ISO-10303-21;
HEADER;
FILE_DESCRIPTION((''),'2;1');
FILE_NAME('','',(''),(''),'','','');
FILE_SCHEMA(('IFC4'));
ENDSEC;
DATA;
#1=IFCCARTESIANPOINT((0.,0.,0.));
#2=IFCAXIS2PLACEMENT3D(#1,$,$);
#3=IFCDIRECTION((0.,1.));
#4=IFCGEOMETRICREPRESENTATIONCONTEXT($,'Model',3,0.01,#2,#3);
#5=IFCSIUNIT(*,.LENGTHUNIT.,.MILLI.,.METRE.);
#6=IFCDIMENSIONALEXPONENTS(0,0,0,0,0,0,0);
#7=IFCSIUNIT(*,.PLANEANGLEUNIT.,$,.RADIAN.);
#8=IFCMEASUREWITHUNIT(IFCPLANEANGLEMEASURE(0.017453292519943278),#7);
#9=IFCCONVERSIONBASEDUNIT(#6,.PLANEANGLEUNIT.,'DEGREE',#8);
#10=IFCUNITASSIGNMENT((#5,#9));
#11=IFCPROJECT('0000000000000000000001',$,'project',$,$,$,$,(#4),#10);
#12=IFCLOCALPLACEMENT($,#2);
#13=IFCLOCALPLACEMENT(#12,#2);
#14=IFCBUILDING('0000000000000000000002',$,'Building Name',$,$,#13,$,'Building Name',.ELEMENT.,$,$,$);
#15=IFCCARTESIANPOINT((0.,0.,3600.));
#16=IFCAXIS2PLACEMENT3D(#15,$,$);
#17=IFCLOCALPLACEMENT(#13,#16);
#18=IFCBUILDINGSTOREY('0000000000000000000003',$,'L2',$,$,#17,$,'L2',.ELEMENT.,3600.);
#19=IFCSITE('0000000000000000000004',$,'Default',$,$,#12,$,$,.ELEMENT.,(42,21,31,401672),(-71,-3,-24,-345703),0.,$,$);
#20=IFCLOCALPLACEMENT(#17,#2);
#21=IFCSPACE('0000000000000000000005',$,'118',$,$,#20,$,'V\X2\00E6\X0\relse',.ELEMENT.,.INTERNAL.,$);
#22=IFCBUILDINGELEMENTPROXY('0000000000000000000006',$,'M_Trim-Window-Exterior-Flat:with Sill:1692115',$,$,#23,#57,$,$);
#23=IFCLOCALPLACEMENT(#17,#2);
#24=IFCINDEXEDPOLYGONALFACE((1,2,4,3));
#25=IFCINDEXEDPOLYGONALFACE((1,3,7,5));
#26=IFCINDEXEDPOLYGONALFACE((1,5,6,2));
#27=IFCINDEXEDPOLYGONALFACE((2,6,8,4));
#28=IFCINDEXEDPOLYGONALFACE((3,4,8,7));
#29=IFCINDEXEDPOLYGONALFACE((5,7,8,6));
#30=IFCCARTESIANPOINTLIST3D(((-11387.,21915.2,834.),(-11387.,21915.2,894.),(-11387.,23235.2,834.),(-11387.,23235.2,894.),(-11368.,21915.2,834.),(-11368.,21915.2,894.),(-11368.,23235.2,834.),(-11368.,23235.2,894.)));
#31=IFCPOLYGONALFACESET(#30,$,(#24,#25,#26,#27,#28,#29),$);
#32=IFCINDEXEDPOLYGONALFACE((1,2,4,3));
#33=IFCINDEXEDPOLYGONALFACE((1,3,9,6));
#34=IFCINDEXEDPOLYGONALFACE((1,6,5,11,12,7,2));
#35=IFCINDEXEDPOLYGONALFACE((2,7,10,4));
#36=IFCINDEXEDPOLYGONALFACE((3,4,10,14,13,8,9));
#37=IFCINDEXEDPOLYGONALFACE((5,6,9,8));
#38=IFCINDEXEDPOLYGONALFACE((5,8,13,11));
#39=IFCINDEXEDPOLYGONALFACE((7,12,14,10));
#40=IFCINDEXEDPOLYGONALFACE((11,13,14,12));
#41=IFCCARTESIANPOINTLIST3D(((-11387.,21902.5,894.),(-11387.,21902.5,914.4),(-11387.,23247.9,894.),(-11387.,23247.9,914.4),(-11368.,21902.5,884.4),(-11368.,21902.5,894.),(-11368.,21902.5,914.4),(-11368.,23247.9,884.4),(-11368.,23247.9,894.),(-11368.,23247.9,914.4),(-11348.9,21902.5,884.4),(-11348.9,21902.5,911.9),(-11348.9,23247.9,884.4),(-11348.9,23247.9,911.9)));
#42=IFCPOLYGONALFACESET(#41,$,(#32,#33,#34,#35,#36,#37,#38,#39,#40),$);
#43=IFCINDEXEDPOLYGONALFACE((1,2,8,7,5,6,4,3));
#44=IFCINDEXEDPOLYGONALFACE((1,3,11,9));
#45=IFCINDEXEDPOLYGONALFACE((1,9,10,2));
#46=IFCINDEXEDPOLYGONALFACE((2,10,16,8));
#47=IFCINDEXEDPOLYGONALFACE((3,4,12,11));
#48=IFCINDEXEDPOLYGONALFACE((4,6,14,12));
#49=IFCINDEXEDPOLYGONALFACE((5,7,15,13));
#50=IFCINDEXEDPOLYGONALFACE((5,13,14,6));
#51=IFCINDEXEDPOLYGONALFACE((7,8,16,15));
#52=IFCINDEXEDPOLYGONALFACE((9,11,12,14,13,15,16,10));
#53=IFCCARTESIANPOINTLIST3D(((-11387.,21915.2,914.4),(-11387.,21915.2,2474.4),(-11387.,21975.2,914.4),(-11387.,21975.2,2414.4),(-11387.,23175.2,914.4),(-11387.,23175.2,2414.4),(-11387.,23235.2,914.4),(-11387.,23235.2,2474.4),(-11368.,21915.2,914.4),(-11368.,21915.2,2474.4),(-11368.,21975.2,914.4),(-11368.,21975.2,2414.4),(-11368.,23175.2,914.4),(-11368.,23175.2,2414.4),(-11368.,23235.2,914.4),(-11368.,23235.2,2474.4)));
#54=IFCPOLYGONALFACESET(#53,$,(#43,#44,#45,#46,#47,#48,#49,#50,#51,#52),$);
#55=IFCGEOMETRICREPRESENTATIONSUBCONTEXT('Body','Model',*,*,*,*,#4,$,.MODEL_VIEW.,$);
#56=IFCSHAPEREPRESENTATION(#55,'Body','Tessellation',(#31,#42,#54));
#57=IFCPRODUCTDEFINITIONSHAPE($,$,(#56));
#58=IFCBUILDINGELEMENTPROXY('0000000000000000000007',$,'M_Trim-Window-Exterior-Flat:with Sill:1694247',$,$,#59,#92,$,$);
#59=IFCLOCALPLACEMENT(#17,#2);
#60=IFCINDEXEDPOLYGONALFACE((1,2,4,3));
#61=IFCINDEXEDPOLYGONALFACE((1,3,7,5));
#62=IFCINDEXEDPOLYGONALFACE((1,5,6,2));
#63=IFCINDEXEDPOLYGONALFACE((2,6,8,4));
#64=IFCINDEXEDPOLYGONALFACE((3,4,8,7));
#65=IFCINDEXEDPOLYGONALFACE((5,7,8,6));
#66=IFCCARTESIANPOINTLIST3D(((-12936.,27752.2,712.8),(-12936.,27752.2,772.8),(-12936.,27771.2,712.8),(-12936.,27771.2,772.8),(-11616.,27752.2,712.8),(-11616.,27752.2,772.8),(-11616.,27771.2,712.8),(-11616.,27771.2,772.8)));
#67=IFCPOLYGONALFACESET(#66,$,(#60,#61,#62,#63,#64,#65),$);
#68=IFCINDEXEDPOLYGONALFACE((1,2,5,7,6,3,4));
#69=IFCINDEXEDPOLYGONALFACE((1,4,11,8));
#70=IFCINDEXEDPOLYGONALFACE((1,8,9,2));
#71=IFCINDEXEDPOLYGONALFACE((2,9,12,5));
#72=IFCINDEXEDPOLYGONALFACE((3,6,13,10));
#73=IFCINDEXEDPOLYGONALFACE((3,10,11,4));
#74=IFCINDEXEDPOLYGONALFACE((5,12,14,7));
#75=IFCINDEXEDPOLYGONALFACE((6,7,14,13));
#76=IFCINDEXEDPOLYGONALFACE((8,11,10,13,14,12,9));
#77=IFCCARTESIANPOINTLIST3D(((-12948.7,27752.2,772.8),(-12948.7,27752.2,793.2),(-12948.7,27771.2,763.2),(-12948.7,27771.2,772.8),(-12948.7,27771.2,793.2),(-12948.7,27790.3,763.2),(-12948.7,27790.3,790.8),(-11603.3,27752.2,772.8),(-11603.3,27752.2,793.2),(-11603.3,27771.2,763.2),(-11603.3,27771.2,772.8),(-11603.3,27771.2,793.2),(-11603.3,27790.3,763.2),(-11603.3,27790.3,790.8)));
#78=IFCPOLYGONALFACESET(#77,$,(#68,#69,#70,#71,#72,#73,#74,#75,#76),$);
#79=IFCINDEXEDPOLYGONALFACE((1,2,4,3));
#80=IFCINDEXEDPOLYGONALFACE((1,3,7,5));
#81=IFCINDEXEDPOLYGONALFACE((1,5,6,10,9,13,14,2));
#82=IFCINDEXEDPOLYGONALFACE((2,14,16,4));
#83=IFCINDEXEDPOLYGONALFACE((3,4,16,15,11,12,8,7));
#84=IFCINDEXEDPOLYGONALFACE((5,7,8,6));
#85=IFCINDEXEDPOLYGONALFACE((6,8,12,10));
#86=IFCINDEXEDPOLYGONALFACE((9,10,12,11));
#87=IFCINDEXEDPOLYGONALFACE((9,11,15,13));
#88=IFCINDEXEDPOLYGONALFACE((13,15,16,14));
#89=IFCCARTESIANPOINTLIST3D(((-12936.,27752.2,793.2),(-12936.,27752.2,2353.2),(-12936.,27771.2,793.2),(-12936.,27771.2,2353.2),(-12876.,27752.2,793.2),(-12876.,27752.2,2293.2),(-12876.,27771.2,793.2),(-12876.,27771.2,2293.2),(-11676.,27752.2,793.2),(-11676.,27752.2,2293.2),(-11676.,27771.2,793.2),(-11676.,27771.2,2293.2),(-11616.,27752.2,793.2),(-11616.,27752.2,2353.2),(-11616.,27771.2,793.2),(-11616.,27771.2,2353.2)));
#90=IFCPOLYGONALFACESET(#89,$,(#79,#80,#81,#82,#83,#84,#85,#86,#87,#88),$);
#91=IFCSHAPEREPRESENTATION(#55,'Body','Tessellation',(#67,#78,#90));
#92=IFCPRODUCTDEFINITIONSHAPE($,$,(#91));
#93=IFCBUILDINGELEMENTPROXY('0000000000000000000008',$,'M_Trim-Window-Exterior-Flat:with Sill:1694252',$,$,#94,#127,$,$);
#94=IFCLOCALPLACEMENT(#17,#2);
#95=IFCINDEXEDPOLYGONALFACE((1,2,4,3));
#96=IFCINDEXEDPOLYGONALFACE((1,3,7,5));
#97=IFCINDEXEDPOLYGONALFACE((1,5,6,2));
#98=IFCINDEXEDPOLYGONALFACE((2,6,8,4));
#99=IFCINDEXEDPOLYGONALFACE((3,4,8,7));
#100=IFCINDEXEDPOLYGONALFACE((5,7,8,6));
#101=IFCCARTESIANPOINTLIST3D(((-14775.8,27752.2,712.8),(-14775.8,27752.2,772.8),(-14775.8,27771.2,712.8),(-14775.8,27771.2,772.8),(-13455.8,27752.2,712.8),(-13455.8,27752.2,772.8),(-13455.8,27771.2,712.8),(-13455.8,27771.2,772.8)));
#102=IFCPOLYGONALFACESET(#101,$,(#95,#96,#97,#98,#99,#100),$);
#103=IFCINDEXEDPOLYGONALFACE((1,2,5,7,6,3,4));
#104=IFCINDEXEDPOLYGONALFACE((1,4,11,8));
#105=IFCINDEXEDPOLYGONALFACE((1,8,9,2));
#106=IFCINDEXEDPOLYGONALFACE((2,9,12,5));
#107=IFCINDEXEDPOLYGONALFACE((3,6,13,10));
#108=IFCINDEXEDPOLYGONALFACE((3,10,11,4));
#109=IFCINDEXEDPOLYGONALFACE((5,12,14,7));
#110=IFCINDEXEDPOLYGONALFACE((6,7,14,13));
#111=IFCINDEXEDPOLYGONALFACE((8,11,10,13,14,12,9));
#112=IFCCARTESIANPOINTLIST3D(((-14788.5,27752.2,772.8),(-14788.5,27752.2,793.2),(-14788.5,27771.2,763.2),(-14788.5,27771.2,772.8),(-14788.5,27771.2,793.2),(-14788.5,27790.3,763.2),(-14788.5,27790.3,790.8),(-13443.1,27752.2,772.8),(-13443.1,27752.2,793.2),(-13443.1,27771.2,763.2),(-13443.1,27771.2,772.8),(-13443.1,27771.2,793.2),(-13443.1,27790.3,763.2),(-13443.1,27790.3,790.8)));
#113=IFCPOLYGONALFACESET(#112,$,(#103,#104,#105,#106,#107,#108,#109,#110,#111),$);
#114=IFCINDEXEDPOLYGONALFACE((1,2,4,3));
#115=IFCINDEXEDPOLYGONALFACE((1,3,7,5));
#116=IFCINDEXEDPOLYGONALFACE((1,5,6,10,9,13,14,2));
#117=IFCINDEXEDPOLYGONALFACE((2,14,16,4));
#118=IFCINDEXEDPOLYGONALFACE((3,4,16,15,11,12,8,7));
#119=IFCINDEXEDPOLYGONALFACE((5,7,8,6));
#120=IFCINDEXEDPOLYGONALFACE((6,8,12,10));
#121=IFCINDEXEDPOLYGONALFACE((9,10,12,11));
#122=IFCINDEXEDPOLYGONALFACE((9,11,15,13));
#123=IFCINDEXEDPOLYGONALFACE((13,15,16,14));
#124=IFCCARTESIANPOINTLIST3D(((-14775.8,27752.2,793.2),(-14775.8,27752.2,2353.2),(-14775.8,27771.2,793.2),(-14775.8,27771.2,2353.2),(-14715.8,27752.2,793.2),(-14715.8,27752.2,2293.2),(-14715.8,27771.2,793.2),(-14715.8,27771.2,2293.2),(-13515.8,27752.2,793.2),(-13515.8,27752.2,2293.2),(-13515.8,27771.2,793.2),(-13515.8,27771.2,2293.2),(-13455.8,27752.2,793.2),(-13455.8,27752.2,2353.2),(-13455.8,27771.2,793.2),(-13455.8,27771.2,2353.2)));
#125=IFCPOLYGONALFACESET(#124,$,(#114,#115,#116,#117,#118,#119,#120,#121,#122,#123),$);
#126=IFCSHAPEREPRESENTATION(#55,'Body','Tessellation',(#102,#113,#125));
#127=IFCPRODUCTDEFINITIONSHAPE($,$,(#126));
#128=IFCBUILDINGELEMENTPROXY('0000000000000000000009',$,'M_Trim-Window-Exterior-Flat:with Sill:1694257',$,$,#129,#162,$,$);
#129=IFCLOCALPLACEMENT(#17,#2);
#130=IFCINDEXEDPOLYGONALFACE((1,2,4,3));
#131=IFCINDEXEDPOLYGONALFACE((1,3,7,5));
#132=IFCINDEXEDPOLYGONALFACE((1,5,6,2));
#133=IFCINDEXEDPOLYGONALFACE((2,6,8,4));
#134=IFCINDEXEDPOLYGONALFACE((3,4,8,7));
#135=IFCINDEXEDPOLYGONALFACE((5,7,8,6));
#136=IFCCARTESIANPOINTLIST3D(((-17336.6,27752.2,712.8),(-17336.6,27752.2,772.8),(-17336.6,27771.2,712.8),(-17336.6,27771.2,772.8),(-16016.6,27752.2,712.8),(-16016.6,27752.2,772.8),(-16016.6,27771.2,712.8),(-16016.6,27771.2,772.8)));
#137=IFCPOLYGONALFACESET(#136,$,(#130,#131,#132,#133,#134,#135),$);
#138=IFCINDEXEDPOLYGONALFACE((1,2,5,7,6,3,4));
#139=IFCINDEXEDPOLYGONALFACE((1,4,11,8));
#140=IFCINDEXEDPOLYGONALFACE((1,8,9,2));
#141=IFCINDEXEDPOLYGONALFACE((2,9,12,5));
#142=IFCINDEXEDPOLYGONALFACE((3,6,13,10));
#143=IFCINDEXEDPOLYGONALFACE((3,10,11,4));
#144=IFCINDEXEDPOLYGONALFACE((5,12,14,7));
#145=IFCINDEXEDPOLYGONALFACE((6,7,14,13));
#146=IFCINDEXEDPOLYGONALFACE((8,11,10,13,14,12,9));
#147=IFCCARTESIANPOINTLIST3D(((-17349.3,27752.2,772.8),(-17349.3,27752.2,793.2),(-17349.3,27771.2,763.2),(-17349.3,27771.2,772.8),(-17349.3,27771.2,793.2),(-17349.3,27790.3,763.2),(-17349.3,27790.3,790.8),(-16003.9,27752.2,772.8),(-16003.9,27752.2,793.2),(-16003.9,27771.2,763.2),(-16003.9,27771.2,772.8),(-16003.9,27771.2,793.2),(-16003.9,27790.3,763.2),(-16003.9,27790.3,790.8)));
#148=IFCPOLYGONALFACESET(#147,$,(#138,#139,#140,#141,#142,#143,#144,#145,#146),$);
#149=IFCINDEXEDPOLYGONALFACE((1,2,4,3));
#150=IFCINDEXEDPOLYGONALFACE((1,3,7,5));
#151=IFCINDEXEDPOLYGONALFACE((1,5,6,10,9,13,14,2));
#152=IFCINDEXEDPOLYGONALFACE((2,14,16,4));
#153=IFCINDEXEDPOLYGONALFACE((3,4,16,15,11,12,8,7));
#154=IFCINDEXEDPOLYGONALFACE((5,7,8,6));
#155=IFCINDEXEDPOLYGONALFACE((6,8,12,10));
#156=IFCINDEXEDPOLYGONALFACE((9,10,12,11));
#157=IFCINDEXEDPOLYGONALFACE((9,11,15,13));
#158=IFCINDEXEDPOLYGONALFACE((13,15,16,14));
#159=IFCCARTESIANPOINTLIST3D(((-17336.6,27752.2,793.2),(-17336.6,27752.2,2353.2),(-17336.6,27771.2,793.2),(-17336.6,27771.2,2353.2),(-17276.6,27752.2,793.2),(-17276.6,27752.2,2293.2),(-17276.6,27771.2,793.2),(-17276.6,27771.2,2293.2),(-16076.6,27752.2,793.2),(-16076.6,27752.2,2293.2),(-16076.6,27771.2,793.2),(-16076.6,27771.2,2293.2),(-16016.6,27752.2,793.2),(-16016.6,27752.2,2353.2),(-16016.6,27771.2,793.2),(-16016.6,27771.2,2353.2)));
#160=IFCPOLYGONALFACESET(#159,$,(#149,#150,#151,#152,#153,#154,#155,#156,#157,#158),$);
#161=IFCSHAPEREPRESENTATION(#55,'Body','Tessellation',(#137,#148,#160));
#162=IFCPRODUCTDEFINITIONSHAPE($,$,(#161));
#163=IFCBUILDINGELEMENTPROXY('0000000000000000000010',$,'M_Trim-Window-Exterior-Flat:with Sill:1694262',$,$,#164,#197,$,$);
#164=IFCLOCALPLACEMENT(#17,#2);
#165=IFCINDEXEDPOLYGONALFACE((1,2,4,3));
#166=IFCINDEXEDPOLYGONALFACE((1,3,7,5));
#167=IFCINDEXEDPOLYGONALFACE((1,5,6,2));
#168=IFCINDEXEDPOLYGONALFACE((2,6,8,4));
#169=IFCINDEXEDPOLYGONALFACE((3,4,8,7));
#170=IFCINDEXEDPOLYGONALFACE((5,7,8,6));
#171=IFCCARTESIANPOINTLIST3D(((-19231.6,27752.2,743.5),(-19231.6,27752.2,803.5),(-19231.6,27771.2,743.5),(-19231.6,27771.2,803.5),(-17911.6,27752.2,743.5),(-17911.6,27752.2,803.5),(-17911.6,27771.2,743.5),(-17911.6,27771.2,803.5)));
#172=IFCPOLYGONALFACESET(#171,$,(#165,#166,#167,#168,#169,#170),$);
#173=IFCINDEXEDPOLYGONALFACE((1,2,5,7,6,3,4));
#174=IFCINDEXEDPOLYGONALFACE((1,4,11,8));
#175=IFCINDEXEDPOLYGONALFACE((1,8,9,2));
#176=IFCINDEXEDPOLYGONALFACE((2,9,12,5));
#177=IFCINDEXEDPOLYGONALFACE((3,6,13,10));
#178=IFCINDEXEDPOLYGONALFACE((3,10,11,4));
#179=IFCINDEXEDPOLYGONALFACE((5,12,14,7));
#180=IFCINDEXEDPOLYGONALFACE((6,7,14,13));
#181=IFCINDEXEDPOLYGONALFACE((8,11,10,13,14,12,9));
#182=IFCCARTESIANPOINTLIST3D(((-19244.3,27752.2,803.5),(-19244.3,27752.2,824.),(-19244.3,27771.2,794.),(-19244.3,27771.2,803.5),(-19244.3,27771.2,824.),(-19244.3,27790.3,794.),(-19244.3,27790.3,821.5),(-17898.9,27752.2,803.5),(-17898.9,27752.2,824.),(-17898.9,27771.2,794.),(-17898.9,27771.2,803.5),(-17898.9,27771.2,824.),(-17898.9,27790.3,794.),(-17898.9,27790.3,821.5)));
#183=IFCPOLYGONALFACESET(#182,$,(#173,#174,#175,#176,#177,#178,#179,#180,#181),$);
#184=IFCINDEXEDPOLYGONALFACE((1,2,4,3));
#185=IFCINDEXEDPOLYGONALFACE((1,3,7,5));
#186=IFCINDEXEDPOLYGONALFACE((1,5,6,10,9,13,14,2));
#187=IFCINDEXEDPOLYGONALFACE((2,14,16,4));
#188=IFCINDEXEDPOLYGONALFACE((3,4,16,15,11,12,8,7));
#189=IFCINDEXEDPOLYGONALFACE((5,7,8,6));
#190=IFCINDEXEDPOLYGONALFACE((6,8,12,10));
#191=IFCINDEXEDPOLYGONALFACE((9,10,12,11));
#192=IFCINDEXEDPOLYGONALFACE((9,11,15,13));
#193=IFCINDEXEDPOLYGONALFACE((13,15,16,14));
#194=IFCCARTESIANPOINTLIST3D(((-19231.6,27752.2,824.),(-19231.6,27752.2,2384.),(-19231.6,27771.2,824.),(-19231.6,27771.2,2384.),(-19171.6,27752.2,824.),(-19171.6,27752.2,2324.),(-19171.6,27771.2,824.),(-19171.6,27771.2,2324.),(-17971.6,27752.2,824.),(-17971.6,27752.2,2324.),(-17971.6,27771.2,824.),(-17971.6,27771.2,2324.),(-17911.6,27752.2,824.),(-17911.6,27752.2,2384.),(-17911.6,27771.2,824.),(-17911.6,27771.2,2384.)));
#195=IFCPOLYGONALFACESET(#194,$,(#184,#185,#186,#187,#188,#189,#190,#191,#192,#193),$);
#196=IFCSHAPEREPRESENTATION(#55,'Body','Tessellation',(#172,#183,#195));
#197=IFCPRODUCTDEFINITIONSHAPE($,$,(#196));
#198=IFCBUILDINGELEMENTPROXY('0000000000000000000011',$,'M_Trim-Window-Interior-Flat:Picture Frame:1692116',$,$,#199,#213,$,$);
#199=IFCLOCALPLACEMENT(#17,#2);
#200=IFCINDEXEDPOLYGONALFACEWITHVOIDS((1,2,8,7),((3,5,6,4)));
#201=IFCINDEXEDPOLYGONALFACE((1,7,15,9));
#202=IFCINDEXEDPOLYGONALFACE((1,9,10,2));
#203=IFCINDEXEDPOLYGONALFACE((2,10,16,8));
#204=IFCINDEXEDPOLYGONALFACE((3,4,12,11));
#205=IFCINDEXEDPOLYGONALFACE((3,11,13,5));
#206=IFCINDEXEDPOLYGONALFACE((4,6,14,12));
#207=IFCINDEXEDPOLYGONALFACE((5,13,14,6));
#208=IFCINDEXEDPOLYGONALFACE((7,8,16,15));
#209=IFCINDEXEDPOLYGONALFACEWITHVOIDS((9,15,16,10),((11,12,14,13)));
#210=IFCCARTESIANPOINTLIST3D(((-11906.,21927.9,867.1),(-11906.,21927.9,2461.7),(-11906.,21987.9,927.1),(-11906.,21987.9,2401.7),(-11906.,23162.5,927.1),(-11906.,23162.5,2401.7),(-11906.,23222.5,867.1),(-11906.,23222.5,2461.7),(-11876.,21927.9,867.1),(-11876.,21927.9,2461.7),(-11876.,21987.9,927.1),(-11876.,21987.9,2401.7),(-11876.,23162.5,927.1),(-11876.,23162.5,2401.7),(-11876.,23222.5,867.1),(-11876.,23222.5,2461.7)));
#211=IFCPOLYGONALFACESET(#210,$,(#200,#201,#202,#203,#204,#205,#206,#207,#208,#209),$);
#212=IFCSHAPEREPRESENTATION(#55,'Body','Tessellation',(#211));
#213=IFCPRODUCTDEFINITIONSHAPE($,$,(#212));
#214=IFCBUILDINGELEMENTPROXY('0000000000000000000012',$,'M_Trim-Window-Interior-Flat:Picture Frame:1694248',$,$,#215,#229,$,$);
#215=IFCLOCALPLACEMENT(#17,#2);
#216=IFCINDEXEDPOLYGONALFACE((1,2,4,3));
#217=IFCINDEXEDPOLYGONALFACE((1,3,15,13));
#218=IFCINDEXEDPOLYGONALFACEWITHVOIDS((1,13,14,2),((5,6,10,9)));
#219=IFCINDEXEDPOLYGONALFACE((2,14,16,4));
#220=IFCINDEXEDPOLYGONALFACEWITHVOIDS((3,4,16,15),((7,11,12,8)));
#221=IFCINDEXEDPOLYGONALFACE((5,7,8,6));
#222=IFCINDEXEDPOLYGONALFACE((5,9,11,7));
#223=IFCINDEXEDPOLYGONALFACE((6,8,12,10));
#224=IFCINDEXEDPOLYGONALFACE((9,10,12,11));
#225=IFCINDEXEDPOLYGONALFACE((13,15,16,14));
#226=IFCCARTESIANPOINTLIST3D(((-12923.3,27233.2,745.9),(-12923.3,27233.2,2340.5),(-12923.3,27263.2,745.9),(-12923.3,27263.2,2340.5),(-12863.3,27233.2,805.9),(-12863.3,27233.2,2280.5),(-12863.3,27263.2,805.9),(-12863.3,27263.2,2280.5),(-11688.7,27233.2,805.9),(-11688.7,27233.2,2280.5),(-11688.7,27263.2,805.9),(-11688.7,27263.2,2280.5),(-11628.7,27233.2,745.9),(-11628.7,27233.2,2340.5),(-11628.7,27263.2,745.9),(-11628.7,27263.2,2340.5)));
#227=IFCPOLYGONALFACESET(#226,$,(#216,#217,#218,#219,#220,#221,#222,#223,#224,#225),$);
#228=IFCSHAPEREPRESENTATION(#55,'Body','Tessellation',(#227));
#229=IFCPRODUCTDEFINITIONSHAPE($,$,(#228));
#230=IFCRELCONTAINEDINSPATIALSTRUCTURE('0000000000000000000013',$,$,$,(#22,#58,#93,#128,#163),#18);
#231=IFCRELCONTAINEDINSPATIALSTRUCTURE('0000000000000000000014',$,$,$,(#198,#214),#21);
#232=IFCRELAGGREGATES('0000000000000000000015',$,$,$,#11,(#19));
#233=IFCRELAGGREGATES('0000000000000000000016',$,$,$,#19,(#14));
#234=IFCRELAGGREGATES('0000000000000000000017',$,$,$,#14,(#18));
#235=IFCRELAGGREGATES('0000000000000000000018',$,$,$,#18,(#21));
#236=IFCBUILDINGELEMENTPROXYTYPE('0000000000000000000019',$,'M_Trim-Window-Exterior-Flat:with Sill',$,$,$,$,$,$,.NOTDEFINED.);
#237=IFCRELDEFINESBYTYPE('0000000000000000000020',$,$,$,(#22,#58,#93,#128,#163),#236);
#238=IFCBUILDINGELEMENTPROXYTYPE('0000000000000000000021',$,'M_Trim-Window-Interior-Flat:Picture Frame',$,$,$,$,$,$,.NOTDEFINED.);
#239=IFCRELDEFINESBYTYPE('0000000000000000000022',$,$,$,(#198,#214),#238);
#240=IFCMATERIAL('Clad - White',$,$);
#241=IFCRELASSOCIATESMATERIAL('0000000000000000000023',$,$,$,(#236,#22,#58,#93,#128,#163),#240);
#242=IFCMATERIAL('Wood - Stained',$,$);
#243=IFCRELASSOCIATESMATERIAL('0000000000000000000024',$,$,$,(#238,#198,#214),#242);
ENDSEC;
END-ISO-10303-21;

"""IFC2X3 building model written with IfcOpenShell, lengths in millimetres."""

from ifc_helpers import new_model, entity, si_unit, converted_unit, direction, frame, frame_2d, origin, place, context, subcontext, project, spatial, polyline, rectangle, outline, extrude, source, transform, mapped, material, type_object, type_shapes, element, save


model = new_model("IFC2X3")

# Units and contexts
model_context = context("Model", 3, precision=0.01, world=origin(), true_north=direction((0.0, 1.0)))
body_context = subcontext(model_context, "Body", "Model", "MODEL_VIEW")
ifc_project = project(units=[si_unit("LENGTHUNIT", "METRE", prefix="MILLI"), converted_unit("PLANEANGLEUNIT", "DEGREE", entity("IfcPlaneAngleMeasure", 0.017453292519943278), si_unit("PLANEANGLEUNIT", "RADIAN"), dimensions=[0, 0, 0, 0, 0, 0, 0])], contexts=[model_context])

# Site, building, storey
site_placement = place(None, origin())
site = spatial("IfcSite", under=ifc_project, at=site_placement, Name="Default", CompositionType="ELEMENT", RefLatitude=(42, 21, 31, 401672), RefLongitude=(-71, -3, -24, -345703), RefElevation=0.0)
building_placement = place(site_placement, origin())
building = spatial("IfcBuilding", under=site, at=building_placement, Name="Building Name", LongName="Building Name", CompositionType="ELEMENT")
storey_placement = place(building_placement, frame((0.0, 0.0, 3600.0)))
storey = spatial("IfcBuildingStorey", under=building, at=storey_placement, Name="L2", LongName="L2", CompositionType="ELEMENT", Elevation=3600.0)

# Shared definitions
ifc_material_1 = material(Name="Wood - Stained")

# Building element proxies
ifc_material_2 = material(Name="Clad - White")
building_element_proxy_type_1 = type_object("IfcBuildingElementProxyType", Name="M_Trim-Window-Exterior-Flat:with Sill", PredefinedType="NOTDEFINED", material=ifc_material_2)
shared_shape_1 = source(origin(), body_context, "Body", "SweptSolid", [
    extrude(rectangle(XDim=1320.0, YDim=60.0, at=frame_2d((0.0, 0.0), x_axis=(1.0, 0.0))), frame((0.0, -1550.4, 0.0), z_axis=(0.0, 0.0, 1.0), x_axis=(-1.0, 0.0, 0.0)), (0.0, 0.0, 1.0), 19.0),
    extrude(outline(polyline([(-19.0, -15.2), (0.0, -15.2), (0.0, -5.7), (19.0, -5.7), (19.0, 14.8), (0.0, 14.8), (-19.0, 12.3), (-19.0, -15.2)])), frame((-672.7, -1514.8, 19.0), z_axis=(1.0, 0.0, 0.0), x_axis=(0.0, 0.0, -1.0)), (0.0, 0.0, 1.0), 1345.4),
    extrude(outline(polyline([(-795.0, -660.0), (765.0, -660.0), (765.0, -600.0), (-735.0, -600.0), (-735.0, 600.0), (765.0, 600.0), (765.0, 660.0), (-795.0, 660.0), (-795.0, -660.0)])), frame((0.0, -735.0, 0.0), z_axis=(0.0, 0.0, 1.0), x_axis=(0.0, -1.0, 0.0)), (0.0, 0.0, 1.0), 19.0),
])
type_shapes(building_element_proxy_type_1, [shared_shape_1])
for number, where, z_axis, x_axis, name in (
    (1, (-11387.0, 22575.2, 2414.4), (1.0, 0.0, 0.0), (0.0, 1.0, 0.0), "M_Trim-Window-Exterior-Flat:with Sill:1692115"),
    (2, (-12276.0, 27752.2, 2293.2), (0.0, 1.0, 0.0), (-1.0, 0.0, 0.0), "M_Trim-Window-Exterior-Flat:with Sill:1694247"),
    (3, (-14115.8, 27752.2, 2293.2), (0.0, 1.0, 0.0), (-1.0, 0.0, 0.0), "M_Trim-Window-Exterior-Flat:with Sill:1694252"),
    (4, (-16676.6, 27752.2, 2293.2), (0.0, 1.0, 0.0), (-1.0, 0.0, 0.0), "M_Trim-Window-Exterior-Flat:with Sill:1694257"),
    (5, (-18571.6, 27752.2, 2324.0), (0.0, 1.0, 0.0), (-1.0, 0.0, 0.0), "M_Trim-Window-Exterior-Flat:with Sill:1694262"),
):
    element("IfcBuildingElementProxy", number, at=place(storey_placement, frame(where, z_axis=z_axis, x_axis=x_axis)), inside=storey, type_object=building_element_proxy_type_1, material=ifc_material_2, Name=name, context=body_context, shape_type="MappedRepresentation", body=[
        mapped(shared_shape_1, transform((0.0, 0.0, 0.0), scale=1.0)),
    ])

# Shared definitions
space_1_placement = place(storey_placement, origin())
space_1 = spatial("IfcSpace", under=storey, at=space_1_placement, Name="118", LongName="Værelse", CompositionType="ELEMENT", InteriorOrExteriorSpace="INTERNAL")

# Building element proxies
building_element_proxy_type_2 = type_object("IfcBuildingElementProxyType", Name="M_Trim-Window-Interior-Flat:Picture Frame", PredefinedType="NOTDEFINED", material=ifc_material_1)
shared_shape_2 = source(origin(), body_context, "Body", "SweptSolid", [
    extrude(outline(polyline([(-647.3, -797.3), (647.3, -797.3), (647.3, 797.3), (-647.3, 797.3), (-647.3, -797.3)]), holes=[polyline([(-587.3, -737.3), (-587.3, 737.3), (587.3, 737.3), (587.3, -737.3), (-587.3, -737.3)])]), frame((0.0, -750.0, 0.0), z_axis=(0.0, 0.0, 1.0), x_axis=(-1.0, 0.0, 0.0)), (0.0, 0.0, 1.0), 30.0),
])
type_shapes(building_element_proxy_type_2, [shared_shape_2])
for number, where, z_axis, x_axis, name in (
    (6, (-11876.0, 22575.2, 2414.4), (-1.0, 0.0, 0.0), (0.0, -1.0, 0.0), "M_Trim-Window-Interior-Flat:Picture Frame:1692116"),
    (7, (-12276.0, 27263.2, 2293.2), (0.0, -1.0, 0.0), (1.0, 0.0, 0.0), "M_Trim-Window-Interior-Flat:Picture Frame:1694248"),
):
    element("IfcBuildingElementProxy", number, at=place(space_1_placement, frame(where, z_axis=z_axis, x_axis=x_axis)), inside=space_1, type_object=building_element_proxy_type_2, material=ifc_material_1, Name=name, context=body_context, shape_type="MappedRepresentation", body=[
        mapped(shared_shape_2, transform((0.0, 0.0, 0.0), scale=1.0)),
    ])

save(model, "model.ifc")
